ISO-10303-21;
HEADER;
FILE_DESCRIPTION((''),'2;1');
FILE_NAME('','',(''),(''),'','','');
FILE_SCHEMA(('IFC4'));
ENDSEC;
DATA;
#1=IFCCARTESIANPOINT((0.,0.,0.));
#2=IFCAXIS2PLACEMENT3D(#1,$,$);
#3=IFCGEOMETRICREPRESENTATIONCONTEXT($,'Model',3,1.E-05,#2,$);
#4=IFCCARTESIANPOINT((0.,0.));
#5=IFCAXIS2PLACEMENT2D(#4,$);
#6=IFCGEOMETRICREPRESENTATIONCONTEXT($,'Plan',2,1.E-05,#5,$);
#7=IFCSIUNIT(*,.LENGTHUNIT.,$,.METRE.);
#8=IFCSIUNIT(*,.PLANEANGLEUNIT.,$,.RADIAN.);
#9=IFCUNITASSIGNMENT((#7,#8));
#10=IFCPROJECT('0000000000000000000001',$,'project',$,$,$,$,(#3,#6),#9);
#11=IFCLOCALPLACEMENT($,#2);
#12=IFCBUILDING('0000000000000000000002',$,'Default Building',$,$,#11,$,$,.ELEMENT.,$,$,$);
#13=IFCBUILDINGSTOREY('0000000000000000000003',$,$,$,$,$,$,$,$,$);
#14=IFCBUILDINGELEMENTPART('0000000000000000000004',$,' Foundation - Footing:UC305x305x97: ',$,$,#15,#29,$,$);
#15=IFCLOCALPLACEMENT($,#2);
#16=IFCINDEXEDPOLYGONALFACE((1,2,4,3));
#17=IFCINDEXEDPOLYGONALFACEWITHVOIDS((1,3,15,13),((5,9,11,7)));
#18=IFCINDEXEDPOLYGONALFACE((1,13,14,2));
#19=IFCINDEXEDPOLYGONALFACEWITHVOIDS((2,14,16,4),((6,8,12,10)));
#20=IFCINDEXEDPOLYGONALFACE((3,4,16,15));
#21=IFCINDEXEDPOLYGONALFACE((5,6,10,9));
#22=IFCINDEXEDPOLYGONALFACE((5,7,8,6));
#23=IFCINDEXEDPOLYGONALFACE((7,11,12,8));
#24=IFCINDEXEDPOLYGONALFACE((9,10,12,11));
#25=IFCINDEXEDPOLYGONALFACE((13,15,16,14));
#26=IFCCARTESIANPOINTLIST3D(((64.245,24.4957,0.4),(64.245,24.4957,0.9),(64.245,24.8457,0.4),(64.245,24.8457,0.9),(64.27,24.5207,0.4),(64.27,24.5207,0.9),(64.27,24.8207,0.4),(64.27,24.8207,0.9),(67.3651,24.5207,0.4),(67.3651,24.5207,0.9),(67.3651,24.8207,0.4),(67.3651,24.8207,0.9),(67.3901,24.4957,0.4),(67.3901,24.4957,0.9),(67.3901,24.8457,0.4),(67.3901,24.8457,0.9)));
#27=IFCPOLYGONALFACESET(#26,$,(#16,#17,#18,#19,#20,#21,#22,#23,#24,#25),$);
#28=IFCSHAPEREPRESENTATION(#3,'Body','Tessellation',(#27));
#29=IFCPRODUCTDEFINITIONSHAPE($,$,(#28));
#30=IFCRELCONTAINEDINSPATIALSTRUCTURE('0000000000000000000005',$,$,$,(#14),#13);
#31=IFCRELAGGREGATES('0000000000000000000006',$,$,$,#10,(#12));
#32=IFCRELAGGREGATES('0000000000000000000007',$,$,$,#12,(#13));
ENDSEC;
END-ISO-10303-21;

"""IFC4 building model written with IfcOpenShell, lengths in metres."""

from ifc_helpers import new_model, si_unit, origin, origin_2d, place, context, project, spatial, polyline, outline, extrude, element, save


model = new_model("IFC4")

# Units and contexts
model_context = context("Model", 3, precision=1e-05, world=origin())
plan_context = context("Plan", 2, precision=1e-05, world=origin_2d())
ifc_project = project(units=[si_unit("LENGTHUNIT", "METRE"), si_unit("PLANEANGLEUNIT", "RADIAN")], contexts=[model_context, plan_context])

# Building, storey
building_placement = place(None, origin())
building = spatial("IfcBuilding", under=ifc_project, at=building_placement, Name="Default Building", CompositionType="ELEMENT")
storey = spatial("IfcBuildingStorey", under=building)

# Building element part, opening
building_element_part_1 = element("IfcBuildingElementPart", 1, inside=storey, Name=" Foundation - Footing:UC305x305x97: ", context=model_context, shape_type="SweptSolid", body=[
    extrude(outline(polyline([(67.3901, 24.4957, 0.4), (67.3901, 24.8457, 0.4), (64.245, 24.8457, 0.4), (64.245, 24.4957, 0.4), (67.3901, 24.4957, 0.4)])), None, (0.0, 0.0, 1.0), 0.5),
])
element("IfcOpeningElement", 2, inside=storey, cuts=building_element_part_1, context=model_context, shape_type="SweptSolid", body=[
    extrude(outline(polyline([(67.3651, 24.5207, 0.4), (67.3651, 24.8207, 0.4), (64.27, 24.8207, 0.4), (64.27, 24.5207, 0.4), (67.3651, 24.5207, 0.4)])), None, (0.0, 0.0, 1.0), 0.5),
])

save(model, "model.ifc")
